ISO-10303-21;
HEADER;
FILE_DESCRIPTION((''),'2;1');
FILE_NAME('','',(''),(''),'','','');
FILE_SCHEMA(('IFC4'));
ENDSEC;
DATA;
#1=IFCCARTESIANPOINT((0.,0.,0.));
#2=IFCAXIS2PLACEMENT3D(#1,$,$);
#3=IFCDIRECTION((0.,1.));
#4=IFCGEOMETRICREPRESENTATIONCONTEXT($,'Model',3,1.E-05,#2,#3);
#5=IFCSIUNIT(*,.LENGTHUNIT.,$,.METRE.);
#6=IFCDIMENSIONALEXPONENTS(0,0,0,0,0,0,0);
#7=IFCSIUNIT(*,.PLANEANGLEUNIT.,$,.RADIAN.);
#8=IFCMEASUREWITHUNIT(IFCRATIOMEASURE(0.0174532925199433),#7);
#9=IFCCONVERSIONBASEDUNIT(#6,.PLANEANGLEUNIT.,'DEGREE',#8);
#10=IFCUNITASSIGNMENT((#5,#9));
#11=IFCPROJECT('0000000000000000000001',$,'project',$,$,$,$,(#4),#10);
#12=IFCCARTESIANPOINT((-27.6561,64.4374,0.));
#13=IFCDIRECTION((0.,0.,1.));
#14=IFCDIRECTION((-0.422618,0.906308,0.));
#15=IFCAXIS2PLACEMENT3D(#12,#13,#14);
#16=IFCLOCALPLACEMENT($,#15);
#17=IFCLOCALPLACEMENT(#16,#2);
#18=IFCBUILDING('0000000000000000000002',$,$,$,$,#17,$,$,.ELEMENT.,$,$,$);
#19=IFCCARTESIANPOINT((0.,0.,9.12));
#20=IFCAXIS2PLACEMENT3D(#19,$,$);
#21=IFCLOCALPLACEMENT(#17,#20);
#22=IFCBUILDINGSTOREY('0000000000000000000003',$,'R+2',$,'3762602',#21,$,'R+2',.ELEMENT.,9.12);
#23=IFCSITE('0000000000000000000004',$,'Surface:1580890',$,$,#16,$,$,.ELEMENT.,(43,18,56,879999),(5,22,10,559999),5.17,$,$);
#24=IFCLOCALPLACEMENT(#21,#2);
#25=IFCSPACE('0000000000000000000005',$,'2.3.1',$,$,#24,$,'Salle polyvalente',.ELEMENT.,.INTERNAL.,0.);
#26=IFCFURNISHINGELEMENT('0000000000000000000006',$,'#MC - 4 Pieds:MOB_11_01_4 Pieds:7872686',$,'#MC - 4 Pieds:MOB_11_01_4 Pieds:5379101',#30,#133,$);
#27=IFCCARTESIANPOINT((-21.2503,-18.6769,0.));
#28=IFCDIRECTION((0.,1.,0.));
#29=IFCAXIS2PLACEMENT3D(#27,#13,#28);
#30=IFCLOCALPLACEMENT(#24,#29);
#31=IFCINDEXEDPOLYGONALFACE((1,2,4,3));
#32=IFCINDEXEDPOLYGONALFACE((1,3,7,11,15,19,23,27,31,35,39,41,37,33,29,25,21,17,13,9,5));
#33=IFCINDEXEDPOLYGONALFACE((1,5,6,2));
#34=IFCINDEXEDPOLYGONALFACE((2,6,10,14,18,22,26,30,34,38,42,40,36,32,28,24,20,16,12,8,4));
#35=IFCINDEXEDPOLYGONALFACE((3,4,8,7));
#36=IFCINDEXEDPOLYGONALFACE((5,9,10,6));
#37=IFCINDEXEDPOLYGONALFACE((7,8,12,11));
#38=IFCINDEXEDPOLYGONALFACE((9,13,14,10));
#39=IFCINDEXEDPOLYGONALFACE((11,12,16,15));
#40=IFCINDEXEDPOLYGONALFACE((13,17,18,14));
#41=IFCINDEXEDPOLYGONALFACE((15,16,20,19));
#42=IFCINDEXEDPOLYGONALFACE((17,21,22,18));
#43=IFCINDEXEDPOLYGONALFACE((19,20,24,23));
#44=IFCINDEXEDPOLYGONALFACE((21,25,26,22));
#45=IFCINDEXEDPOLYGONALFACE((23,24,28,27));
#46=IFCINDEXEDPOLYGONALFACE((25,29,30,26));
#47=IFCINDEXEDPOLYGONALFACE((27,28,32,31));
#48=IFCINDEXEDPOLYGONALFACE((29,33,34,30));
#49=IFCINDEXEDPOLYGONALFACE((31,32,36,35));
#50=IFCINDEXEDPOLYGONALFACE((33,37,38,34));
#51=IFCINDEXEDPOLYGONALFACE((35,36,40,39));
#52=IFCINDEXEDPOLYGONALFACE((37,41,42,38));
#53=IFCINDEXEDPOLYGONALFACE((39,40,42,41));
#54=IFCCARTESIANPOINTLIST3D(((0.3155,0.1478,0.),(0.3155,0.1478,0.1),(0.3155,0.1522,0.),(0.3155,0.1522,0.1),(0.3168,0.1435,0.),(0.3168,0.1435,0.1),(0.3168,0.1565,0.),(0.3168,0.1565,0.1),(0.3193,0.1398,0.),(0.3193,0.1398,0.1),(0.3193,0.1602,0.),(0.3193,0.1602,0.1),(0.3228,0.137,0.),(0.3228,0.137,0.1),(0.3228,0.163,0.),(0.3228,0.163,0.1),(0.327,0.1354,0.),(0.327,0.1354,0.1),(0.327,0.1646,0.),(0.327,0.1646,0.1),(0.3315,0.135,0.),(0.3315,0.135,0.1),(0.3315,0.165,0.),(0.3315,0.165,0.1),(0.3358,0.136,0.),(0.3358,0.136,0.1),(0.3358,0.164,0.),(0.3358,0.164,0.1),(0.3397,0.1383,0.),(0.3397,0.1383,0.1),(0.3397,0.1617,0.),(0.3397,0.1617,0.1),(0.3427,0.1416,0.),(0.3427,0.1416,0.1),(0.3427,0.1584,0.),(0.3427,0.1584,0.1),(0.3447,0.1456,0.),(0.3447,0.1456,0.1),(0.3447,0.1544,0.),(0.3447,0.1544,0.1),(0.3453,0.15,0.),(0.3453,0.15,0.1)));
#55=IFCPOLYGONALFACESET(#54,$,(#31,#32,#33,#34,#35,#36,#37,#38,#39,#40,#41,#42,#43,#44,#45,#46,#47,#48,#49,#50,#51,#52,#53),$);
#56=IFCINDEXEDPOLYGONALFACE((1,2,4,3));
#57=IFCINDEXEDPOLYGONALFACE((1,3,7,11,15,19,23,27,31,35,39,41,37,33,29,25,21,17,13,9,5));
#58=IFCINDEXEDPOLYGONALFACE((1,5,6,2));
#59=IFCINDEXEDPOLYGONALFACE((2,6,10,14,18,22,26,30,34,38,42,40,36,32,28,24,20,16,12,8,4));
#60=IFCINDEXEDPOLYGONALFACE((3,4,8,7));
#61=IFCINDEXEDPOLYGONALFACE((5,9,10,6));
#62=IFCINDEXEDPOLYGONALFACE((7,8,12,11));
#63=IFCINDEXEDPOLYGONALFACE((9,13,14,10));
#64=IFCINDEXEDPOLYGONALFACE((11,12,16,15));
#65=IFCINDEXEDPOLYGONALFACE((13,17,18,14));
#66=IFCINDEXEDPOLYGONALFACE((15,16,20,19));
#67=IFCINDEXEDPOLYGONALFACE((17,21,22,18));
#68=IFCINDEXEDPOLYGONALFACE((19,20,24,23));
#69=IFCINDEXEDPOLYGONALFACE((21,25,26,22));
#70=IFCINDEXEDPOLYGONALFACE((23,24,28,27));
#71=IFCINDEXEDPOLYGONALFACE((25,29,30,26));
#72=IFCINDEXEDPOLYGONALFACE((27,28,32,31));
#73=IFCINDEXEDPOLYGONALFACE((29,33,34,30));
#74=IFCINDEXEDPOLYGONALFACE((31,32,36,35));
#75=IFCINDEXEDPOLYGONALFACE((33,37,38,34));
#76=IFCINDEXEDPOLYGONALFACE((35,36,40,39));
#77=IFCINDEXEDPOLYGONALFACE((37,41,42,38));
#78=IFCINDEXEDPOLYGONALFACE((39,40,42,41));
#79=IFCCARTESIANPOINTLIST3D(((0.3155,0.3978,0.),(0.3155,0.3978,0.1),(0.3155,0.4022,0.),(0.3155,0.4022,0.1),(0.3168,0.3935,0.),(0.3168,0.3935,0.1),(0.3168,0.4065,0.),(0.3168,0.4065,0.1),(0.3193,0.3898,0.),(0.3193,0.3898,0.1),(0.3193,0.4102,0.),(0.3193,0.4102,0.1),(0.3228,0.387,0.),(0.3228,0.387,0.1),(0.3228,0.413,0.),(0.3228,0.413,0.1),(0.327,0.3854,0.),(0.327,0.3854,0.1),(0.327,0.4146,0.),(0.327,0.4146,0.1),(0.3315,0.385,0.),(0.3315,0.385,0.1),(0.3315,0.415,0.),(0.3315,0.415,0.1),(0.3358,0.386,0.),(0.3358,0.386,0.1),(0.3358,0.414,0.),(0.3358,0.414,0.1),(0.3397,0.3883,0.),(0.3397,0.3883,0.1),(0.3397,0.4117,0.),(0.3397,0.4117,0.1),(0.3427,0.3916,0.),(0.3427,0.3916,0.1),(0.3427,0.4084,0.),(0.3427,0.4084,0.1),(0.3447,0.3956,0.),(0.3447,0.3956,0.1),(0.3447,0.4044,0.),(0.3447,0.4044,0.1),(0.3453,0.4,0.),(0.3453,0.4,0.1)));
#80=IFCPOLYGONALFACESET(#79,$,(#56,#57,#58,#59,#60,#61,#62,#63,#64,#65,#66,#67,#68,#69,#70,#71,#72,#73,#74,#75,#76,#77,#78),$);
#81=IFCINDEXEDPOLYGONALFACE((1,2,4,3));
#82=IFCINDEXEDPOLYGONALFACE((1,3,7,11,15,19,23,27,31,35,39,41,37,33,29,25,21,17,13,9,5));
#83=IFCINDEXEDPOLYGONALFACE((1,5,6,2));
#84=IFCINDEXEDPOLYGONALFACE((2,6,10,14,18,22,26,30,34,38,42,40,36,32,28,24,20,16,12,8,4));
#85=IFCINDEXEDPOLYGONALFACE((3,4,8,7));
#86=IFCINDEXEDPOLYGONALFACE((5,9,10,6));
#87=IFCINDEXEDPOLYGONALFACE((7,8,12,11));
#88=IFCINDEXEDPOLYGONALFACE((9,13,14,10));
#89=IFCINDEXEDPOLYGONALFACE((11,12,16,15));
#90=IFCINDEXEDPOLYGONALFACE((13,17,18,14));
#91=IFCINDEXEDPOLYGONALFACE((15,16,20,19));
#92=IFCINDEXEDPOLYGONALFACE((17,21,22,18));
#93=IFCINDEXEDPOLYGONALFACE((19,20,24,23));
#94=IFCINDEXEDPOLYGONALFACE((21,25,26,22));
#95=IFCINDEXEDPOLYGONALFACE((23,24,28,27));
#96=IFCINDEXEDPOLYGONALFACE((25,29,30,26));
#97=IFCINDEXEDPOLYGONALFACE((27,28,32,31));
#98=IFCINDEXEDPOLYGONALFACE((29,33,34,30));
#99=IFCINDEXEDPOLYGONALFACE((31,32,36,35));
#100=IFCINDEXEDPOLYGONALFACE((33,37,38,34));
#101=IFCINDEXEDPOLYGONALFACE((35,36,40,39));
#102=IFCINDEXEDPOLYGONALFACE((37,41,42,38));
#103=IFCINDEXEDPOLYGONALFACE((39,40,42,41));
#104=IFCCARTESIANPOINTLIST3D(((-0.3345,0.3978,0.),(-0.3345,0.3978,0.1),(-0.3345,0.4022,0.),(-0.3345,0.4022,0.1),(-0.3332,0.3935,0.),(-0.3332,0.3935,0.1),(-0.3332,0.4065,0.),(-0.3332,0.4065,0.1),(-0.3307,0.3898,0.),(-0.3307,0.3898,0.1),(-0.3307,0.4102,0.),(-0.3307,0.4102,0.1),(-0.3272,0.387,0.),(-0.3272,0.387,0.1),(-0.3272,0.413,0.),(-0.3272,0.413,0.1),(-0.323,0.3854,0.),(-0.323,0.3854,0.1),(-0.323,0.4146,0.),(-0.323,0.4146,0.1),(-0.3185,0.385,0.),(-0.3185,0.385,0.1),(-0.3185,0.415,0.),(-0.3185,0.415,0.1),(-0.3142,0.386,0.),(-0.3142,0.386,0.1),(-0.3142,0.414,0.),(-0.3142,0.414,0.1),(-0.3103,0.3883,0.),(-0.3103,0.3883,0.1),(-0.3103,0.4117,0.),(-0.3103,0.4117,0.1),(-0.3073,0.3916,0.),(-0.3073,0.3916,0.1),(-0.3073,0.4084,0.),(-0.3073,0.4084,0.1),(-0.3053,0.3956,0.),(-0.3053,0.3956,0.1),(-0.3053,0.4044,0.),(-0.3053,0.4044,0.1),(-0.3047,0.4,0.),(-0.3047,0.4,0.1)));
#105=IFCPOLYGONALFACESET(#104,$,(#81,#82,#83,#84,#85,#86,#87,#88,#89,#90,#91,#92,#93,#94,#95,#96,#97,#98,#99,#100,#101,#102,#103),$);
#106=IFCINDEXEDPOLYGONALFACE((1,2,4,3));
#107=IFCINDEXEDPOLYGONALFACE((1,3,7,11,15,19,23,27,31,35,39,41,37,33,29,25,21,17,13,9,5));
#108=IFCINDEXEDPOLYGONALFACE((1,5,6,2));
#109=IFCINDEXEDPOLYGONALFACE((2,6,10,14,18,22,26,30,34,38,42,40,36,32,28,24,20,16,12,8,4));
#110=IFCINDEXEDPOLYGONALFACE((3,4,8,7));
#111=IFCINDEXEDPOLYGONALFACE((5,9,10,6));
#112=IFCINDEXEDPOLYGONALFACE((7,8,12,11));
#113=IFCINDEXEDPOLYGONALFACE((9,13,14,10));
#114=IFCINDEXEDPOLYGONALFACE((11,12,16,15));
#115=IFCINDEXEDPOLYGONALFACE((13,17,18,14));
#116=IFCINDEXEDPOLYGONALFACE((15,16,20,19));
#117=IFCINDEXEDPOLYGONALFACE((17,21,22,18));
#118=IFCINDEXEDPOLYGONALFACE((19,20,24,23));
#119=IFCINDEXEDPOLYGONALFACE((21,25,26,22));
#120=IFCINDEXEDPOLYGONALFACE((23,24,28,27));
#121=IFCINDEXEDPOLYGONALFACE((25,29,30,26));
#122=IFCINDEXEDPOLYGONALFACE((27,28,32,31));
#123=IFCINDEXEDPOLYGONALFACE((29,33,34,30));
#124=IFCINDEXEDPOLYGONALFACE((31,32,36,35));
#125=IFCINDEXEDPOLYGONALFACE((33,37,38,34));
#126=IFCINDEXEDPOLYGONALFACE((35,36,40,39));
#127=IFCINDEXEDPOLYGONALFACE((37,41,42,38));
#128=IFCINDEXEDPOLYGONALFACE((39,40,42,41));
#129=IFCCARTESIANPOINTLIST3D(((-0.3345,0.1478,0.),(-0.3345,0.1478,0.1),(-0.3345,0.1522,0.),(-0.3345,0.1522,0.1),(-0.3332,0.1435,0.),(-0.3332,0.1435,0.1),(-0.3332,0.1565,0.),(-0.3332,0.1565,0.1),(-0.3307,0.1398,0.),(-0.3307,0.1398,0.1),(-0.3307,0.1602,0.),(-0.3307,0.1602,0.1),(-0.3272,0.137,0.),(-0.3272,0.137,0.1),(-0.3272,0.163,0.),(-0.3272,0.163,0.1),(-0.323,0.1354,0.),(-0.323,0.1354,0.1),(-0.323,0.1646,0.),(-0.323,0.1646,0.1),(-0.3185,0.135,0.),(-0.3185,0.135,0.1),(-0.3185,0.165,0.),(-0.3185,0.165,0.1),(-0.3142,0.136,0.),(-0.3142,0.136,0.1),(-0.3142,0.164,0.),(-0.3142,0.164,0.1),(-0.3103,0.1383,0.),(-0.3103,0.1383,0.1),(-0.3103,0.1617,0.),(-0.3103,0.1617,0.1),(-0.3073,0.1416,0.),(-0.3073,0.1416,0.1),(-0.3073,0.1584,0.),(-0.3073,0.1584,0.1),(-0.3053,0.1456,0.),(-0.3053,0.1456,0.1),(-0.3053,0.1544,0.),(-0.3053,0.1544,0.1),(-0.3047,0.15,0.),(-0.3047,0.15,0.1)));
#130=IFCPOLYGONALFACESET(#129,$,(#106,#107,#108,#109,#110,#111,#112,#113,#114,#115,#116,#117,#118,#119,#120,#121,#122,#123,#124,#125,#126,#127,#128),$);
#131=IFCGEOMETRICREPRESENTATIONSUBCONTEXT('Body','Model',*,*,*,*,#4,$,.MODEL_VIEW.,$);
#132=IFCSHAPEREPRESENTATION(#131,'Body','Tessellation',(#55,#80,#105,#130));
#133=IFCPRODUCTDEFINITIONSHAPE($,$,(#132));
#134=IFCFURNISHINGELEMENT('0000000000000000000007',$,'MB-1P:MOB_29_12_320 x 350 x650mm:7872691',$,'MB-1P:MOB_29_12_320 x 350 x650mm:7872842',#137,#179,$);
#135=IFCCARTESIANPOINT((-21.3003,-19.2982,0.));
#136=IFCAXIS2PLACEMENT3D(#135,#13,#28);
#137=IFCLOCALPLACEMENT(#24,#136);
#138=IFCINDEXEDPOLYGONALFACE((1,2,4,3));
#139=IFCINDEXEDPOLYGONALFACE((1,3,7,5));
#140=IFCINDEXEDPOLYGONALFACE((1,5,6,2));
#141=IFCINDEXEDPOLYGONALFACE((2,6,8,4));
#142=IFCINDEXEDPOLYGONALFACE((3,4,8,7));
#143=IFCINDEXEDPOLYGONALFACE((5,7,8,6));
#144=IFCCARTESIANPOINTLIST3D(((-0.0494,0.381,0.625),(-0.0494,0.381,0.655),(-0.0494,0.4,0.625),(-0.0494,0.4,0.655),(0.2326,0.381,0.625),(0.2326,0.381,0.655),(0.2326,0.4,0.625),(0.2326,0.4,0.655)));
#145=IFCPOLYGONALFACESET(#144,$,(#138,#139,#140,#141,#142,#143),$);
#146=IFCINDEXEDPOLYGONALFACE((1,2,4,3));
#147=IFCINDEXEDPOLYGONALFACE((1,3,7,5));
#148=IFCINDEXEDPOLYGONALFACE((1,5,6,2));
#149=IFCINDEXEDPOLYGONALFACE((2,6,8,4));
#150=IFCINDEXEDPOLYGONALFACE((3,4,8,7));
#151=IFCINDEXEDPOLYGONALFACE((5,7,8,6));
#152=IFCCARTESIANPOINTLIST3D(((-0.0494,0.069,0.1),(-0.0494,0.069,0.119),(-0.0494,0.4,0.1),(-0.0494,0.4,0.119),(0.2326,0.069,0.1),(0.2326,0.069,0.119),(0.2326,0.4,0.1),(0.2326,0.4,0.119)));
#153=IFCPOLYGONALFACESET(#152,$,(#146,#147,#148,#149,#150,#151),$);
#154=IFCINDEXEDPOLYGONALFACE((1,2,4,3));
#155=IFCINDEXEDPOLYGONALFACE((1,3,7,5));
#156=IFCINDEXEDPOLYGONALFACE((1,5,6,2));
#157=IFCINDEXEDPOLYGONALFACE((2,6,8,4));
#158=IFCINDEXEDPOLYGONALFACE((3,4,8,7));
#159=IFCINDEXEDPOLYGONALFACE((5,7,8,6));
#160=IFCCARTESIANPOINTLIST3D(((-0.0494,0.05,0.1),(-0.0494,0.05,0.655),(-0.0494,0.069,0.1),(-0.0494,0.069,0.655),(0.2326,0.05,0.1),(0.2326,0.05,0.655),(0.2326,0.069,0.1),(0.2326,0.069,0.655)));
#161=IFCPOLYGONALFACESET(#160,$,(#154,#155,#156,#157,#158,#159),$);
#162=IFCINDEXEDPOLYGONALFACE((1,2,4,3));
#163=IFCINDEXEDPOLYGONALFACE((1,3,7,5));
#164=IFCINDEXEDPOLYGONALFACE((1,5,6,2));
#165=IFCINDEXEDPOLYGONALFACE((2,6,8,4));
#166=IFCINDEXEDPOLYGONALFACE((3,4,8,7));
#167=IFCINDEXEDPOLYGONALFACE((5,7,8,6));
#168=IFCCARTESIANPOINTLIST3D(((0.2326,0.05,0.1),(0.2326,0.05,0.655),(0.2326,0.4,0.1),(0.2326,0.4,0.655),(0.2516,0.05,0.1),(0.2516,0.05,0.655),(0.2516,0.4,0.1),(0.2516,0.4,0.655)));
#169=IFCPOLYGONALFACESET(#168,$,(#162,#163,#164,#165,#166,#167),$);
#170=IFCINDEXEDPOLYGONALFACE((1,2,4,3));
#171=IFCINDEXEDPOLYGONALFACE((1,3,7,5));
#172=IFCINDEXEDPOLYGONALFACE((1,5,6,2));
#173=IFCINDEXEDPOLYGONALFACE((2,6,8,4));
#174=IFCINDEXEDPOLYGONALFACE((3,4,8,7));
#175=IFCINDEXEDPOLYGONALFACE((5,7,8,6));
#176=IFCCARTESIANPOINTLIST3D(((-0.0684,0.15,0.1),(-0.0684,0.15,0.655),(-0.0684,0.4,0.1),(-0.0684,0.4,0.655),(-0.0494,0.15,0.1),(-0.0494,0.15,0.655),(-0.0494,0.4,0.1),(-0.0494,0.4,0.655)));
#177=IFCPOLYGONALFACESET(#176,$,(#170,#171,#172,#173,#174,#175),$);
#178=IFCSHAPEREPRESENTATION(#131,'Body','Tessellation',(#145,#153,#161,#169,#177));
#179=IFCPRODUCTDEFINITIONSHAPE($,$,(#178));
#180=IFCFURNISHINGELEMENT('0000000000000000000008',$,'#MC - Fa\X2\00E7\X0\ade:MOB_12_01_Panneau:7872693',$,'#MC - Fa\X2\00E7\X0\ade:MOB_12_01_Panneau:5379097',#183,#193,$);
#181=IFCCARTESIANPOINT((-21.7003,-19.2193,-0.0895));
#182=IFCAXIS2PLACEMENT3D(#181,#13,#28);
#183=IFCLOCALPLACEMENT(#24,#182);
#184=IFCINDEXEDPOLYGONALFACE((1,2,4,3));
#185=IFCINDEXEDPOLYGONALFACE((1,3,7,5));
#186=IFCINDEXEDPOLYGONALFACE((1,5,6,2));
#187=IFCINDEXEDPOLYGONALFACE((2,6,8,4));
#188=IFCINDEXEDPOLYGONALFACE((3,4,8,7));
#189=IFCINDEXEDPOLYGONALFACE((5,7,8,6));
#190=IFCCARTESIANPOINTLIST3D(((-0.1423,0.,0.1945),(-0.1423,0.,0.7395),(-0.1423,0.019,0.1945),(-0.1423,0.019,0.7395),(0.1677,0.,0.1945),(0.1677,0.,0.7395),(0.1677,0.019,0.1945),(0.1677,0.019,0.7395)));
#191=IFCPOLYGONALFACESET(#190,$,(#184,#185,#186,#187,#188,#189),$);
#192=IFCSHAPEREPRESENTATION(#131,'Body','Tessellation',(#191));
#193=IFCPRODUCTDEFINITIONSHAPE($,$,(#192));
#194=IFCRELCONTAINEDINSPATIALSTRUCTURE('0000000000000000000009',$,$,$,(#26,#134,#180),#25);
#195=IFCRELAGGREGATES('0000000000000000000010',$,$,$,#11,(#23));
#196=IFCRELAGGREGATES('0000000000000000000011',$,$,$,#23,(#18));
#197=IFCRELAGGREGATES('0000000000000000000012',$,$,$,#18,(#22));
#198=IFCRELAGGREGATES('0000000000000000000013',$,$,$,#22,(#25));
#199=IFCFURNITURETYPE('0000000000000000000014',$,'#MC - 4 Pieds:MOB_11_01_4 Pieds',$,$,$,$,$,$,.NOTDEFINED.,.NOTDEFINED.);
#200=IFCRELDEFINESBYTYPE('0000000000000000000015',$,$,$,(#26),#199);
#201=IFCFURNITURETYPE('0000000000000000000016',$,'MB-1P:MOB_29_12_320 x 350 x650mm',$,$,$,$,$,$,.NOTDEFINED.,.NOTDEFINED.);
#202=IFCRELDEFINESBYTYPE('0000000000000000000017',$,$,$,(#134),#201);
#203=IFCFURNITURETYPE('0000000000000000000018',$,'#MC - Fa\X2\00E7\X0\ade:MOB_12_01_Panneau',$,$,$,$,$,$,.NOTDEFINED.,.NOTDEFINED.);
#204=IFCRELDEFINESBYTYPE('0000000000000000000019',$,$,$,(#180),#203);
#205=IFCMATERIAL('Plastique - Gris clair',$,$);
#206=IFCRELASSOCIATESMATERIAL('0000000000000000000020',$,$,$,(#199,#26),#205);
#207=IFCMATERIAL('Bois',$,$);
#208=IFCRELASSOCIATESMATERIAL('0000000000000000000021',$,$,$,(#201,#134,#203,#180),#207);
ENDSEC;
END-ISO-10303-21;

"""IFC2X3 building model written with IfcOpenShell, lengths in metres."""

from ifc_helpers import new_model, entity, si_unit, converted_unit, direction, frame, frame_2d, origin, origin_2d_with_axis, place, context, subcontext, project, spatial, rectangle, circle, extrude, source, transform, mapped, material, type_object, type_shapes, element, save


model = new_model("IFC2X3")

# Units and contexts
model_context = context("Model", 3, precision=1e-05, world=origin(), true_north=direction((0.0, 1.0)))
body_context = subcontext(model_context, "Body", "Model", "MODEL_VIEW")
ifc_project = project(units=[si_unit("LENGTHUNIT", "METRE"), converted_unit("PLANEANGLEUNIT", "DEGREE", entity("IfcRatioMeasure", 0.0174532925199433), si_unit("PLANEANGLEUNIT", "RADIAN"), dimensions=[0, 0, 0, 0, 0, 0, 0])], contexts=[model_context])

# Site, building, storey
site_placement = place(None, frame((-27.6561, 64.4374, 0.0), z_axis=(0.0, 0.0, 1.0), x_axis=(-0.422618, 0.906308, 0.0)))
site = spatial("IfcSite", under=ifc_project, at=site_placement, Name="Surface:1580890", CompositionType="ELEMENT", RefLatitude=(43, 18, 56, 879999), RefLongitude=(5, 22, 10, 559999), RefElevation=5.17)
building_placement = place(site_placement, origin())
building = spatial("IfcBuilding", under=site, at=building_placement, CompositionType="ELEMENT")
storey_placement = place(building_placement, frame((0.0, 0.0, 9.12)))
storey = spatial("IfcBuildingStorey", under=building, at=storey_placement, Name="R+2", ObjectType="3762602", LongName="R+2", CompositionType="ELEMENT", Elevation=9.12)

# Shared definitions
space_placement = place(storey_placement, origin())
space = spatial("IfcSpace", under=storey, at=space_placement, Name="2.3.1", LongName="Salle polyvalente", CompositionType="ELEMENT", InteriorOrExteriorSpace="INTERNAL", ElevationWithFlooring=0.0)

# Furnishing elements
ifc_material_1 = material(Name="Bois")
ifc_material_2 = material(Name="Plastique - Gris clair")
furniture_type_1 = type_object("IfcFurnitureType", Name="#MC - 4 Pieds:MOB_11_01_4 Pieds", material=ifc_material_2)
shared_shape_1 = source(origin(), body_context, "Body", "SweptSolid", [
    extrude(circle(Radius=0.015, at=frame_2d((0.0, 0.0), x_axis=(1.0, 0.0))), frame((0.3303, 0.15, 0.0)), (0.0, 0.0, 1.0), 0.1),
    extrude(circle(Radius=0.015, at=frame_2d((0.0, 0.0), x_axis=(1.0, 0.0))), frame((0.3303, 0.4, 0.0)), (0.0, 0.0, 1.0), 0.1),
    extrude(circle(Radius=0.015, at=origin_2d_with_axis()), frame((-0.3197, 0.4, 0.0)), (0.0, 0.0, 1.0), 0.1),
    extrude(circle(Radius=0.015, at=frame_2d((0.0, 0.0), x_axis=(1.0, 0.0))), frame((-0.3197, 0.15, 0.0)), (0.0, 0.0, 1.0), 0.1),
])
type_shapes(furniture_type_1, [shared_shape_1])
for number, where, z_axis, x_axis, name in (
    (1, (-21.2503, -18.6769, 0.0), (0.0, 0.0, 1.0), (0.0, 1.0, 0.0), "#MC - 4 Pieds:MOB_11_01_4 Pieds:7872686"),
):
    element("IfcFurnishingElement", number, at=place(space_placement, frame(where, z_axis=z_axis, x_axis=x_axis)), inside=space, type_object=furniture_type_1, material=ifc_material_2, Name=name, ObjectType="#MC - 4 Pieds:MOB_11_01_4 Pieds:5379101", context=body_context, shape_type="MappedRepresentation", body=[
        mapped(shared_shape_1, transform((0.0, 0.0, 0.0), scale=1.0)),
    ])
furniture_type_2 = type_object("IfcFurnitureType", Name="MB-1P:MOB_29_12_320 x 350 x650mm", material=ifc_material_1)
shared_shape_2 = source(origin(), body_context, "Body", "SweptSolid", [
    extrude(rectangle(XDim=0.019, YDim=0.282, at=frame_2d((0.0, 0.0), x_axis=(1.0, 0.0))), frame((0.0916, 0.3905, 0.625), z_axis=(0.0, 0.0, 1.0), x_axis=(0.0, 1.0, 0.0)), (0.0, 0.0, 1.0), 0.03),
    extrude(rectangle(XDim=0.282, YDim=0.331, at=origin_2d_with_axis()), frame((0.0916, 0.2345, 0.1), z_axis=(0.0, 0.0, 1.0), x_axis=(-1.0, 0.0, 0.0)), (0.0, 0.0, 1.0), 0.019),
    extrude(rectangle(XDim=0.019, YDim=0.282, at=origin_2d_with_axis()), frame((0.0916, 0.0595, 0.1), z_axis=(0.0, 0.0, 1.0), x_axis=(0.0, 1.0, 0.0)), (0.0, 0.0, 1.0), 0.555),
    extrude(rectangle(XDim=0.019, YDim=0.35, at=origin_2d_with_axis()), frame((0.2421, 0.225, 0.1), z_axis=(0.0, 0.0, 1.0), x_axis=(-1.0, 0.0, 0.0)), (0.0, 0.0, 1.0), 0.555),
    extrude(rectangle(XDim=0.019, YDim=0.25, at=origin_2d_with_axis()), frame((-0.0589, 0.275, 0.1), z_axis=(0.0, 0.0, 1.0), x_axis=(-1.0, 0.0, 0.0)), (0.0, 0.0, 1.0), 0.555),
])
type_shapes(furniture_type_2, [shared_shape_2])
furnishing_1_placement = place(space_placement, frame((-21.3003, -19.2982, 0.0), z_axis=(0.0, 0.0, 1.0), x_axis=(0.0, 1.0, 0.0)))
element("IfcFurnishingElement", 2, at=furnishing_1_placement, inside=space, type_object=furniture_type_2, material=ifc_material_1, Name="MB-1P:MOB_29_12_320 x 350 x650mm:7872691", ObjectType="MB-1P:MOB_29_12_320 x 350 x650mm:7872842", context=body_context, shape_type="MappedRepresentation", body=[
    mapped(shared_shape_2, transform((0.0, 0.0, 0.0), scale=1.0)),
])
furniture_type_3 = type_object("IfcFurnitureType", Name="#MC - Façade:MOB_12_01_Panneau", material=ifc_material_1)
shared_shape_3 = source(origin(), body_context, "Body", "SweptSolid", [
    extrude(rectangle(XDim=0.019, YDim=0.31, at=origin_2d_with_axis()), frame((0.0127, 0.0095, 0.1945), z_axis=(0.0, 0.0, 1.0), x_axis=(0.0, 1.0, 0.0)), (0.0, 0.0, 1.0), 0.545),
])
type_shapes(furniture_type_3, [shared_shape_3])
furnishing_2_placement = place(space_placement, frame((-21.7003, -19.2193, -0.0895), z_axis=(0.0, 0.0, 1.0), x_axis=(0.0, 1.0, 0.0)))
element("IfcFurnishingElement", 3, at=furnishing_2_placement, inside=space, type_object=furniture_type_3, material=ifc_material_1, Name="#MC - Façade:MOB_12_01_Panneau:7872693", ObjectType="#MC - Façade:MOB_12_01_Panneau:5379097", context=body_context, shape_type="MappedRepresentation", body=[
    mapped(shared_shape_3, transform((0.0, 0.0, 0.0), scale=1.0)),
])

save(model, "model.ifc")
